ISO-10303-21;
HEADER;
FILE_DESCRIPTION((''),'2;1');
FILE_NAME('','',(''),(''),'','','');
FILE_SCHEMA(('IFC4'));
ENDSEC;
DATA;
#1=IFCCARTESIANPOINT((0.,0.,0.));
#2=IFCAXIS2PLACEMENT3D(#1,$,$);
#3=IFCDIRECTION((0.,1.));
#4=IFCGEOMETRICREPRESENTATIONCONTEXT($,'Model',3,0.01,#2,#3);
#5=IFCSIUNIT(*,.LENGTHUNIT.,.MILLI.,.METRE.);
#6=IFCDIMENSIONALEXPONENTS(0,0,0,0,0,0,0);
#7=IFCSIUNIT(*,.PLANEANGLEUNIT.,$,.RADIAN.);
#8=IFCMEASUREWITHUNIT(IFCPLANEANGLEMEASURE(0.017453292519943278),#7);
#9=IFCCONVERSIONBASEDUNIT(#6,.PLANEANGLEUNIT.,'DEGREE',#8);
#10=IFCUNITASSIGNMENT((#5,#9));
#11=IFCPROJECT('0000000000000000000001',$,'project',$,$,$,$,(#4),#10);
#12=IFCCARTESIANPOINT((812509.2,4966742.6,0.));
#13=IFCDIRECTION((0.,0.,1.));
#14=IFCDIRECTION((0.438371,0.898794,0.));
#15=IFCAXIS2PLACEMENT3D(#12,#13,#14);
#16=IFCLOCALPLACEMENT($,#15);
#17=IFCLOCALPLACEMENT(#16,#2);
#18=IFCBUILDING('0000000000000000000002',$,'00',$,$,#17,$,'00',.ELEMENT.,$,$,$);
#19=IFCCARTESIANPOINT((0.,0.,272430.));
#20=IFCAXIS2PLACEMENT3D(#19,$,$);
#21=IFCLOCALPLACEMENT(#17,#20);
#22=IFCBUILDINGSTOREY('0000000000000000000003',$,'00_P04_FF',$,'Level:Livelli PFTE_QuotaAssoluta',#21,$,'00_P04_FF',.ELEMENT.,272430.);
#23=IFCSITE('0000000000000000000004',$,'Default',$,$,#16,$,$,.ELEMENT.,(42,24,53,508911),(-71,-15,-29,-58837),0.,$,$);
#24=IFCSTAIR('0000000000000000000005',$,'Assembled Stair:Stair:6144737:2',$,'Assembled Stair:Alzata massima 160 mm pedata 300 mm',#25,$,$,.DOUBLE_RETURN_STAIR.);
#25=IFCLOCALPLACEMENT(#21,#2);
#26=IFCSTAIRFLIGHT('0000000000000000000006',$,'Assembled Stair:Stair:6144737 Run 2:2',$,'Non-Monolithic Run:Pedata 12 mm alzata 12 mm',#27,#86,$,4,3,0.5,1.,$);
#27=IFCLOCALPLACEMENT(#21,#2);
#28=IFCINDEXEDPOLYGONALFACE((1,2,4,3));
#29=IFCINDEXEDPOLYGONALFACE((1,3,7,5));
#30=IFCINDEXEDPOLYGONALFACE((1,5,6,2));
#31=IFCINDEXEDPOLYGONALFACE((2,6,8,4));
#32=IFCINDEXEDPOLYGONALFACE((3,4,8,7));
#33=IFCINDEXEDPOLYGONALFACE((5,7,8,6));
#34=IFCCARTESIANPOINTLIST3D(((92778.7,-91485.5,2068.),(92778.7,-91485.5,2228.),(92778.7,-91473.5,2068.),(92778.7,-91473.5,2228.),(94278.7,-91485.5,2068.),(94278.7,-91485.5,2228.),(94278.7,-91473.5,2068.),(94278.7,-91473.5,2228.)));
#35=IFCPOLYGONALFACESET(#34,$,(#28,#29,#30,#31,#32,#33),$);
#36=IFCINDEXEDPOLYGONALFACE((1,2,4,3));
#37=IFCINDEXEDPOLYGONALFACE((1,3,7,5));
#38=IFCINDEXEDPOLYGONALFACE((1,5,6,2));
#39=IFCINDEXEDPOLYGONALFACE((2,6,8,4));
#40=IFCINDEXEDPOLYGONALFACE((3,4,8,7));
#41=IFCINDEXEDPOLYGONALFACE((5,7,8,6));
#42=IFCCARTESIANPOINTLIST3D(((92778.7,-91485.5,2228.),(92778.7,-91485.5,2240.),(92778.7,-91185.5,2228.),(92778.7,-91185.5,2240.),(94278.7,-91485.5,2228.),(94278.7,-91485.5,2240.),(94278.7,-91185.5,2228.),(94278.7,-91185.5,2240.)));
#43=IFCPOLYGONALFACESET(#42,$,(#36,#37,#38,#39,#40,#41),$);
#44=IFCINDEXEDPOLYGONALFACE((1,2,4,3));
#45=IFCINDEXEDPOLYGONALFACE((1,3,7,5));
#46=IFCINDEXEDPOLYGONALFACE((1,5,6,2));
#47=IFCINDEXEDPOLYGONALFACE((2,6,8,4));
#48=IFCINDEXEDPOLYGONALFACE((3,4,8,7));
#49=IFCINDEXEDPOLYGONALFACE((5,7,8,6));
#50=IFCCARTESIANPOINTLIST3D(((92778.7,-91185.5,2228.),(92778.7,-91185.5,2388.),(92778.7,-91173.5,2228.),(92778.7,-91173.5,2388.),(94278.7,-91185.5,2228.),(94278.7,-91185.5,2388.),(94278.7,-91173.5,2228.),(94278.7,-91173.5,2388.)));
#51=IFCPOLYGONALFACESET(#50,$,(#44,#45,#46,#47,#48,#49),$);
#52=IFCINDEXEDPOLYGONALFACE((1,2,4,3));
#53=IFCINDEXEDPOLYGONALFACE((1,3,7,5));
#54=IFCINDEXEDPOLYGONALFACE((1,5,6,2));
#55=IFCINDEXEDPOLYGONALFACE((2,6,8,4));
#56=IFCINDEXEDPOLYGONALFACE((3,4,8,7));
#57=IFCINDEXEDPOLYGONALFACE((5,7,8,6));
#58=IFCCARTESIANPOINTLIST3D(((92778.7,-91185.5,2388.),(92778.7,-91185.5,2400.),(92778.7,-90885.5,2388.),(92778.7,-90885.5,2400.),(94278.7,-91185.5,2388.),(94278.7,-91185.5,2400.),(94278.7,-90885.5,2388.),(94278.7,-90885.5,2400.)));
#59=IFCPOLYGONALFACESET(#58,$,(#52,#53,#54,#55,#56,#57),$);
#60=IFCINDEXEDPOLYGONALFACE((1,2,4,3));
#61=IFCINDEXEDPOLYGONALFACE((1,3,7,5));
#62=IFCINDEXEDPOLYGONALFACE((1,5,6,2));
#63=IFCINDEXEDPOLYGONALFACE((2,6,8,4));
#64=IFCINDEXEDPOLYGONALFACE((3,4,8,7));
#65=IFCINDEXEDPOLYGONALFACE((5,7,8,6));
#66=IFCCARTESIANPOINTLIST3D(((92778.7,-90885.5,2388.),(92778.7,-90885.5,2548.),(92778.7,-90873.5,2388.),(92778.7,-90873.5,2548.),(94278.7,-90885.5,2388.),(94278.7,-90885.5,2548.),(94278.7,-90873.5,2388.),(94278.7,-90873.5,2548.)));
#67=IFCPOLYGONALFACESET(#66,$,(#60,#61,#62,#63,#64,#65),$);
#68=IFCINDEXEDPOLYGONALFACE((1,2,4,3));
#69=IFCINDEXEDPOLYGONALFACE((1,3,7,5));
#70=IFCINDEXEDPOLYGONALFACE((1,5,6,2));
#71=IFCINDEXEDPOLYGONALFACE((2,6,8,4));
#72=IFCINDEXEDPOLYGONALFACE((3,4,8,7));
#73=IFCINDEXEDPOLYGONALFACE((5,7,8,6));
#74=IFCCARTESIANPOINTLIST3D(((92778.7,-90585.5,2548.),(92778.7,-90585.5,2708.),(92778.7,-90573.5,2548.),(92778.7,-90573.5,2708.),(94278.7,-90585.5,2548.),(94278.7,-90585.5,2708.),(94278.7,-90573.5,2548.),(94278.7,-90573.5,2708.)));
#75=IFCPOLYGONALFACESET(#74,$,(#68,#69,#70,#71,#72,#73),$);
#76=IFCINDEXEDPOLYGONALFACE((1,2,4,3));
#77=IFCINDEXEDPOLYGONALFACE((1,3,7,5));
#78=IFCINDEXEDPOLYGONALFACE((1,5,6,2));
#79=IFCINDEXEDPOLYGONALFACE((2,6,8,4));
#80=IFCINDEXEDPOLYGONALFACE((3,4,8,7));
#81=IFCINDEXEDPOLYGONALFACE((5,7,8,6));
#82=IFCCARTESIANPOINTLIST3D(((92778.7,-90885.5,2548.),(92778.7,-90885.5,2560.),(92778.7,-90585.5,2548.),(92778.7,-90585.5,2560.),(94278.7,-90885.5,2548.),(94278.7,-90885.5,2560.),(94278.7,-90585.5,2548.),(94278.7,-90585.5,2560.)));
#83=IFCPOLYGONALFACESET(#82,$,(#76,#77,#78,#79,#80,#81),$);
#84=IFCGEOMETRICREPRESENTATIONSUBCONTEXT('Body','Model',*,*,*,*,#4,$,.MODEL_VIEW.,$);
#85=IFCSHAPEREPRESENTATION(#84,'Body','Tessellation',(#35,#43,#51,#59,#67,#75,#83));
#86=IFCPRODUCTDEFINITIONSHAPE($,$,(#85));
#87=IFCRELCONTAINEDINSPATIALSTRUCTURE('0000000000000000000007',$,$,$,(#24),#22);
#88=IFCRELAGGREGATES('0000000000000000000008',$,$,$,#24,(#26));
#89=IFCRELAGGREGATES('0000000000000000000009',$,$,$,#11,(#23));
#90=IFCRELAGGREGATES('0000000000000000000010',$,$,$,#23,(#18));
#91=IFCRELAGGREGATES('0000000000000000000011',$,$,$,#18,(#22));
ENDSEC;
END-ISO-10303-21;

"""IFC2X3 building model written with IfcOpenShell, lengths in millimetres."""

from ifc_helpers import new_model, entity, si_unit, converted_unit, direction, frame, frame_2d, origin, origin_2d_with_axis, place, context, subcontext, project, spatial, rectangle, extrude, element, aggregate, save


model = new_model("IFC2X3")

# Units and contexts
model_context = context("Model", 3, precision=0.01, world=origin(), true_north=direction((0.0, 1.0)))
body_context = subcontext(model_context, "Body", "Model", "MODEL_VIEW")
ifc_project = project(units=[si_unit("LENGTHUNIT", "METRE", prefix="MILLI"), converted_unit("PLANEANGLEUNIT", "DEGREE", entity("IfcPlaneAngleMeasure", 0.017453292519943278), si_unit("PLANEANGLEUNIT", "RADIAN"), dimensions=[0, 0, 0, 0, 0, 0, 0])], contexts=[model_context])

# Site, building, storey
site_placement = place(None, frame((812509.2, 4966742.6, 0.0), z_axis=(0.0, 0.0, 1.0), x_axis=(0.438371, 0.898794, 0.0)))
site = spatial("IfcSite", under=ifc_project, at=site_placement, Name="Default", CompositionType="ELEMENT", RefLatitude=(42, 24, 53, 508911), RefLongitude=(-71, -15, -29, -58837), RefElevation=0.0)
building_placement = place(site_placement, origin())
building = spatial("IfcBuilding", under=site, at=building_placement, Name="00", LongName="00", CompositionType="ELEMENT")
storey_placement = place(building_placement, frame((0.0, 0.0, 272430.0)))
storey = spatial("IfcBuildingStorey", under=building, at=storey_placement, Name="00_P04_FF", ObjectType="Level:Livelli PFTE_QuotaAssoluta", LongName="00_P04_FF", CompositionType="ELEMENT", Elevation=272430.0)

# Stair
stair_1_placement = place(storey_placement, origin())
stair_1 = element("IfcStair", 1, at=stair_1_placement, inside=storey, Name="Assembled Stair:Stair:6144737:2", ObjectType="Assembled Stair:Alzata massima 160 mm pedata 300 mm", ShapeType="DOUBLE_RETURN_STAIR")

# Stair flight
stair_flight_1_placement = place(stair_1_placement, origin())
stair_flight_1 = element("IfcStairFlight", 2, at=stair_flight_1_placement, Name="Assembled Stair:Stair:6144737 Run 2:2", ObjectType="Non-Monolithic Run:Pedata 12 mm alzata 12 mm", NumberOfRiser=4, NumberOfTreads=3, RiserHeight=0.5, TreadLength=1.0, context=body_context, shape_type="SweptSolid", body=[
    extrude(rectangle(XDim=1500.0, YDim=12.0, at=origin_2d_with_axis()), frame((93528.7, -91479.5, 2068.0), z_axis=(0.0, 0.0, 1.0), x_axis=(-1.0, 0.0, 0.0)), (0.0, 0.0, 1.0), 160.0),
    extrude(rectangle(XDim=300.0, YDim=1500.0, at=frame_2d((0.0, 0.0), x_axis=(1.0, 0.0))), frame((93528.7, -91335.5, 2228.0), z_axis=(0.0, 0.0, 1.0), x_axis=(0.0, -1.0, 0.0)), (0.0, 0.0, 1.0), 12.0),
    extrude(rectangle(XDim=1500.0, YDim=12.0, at=frame_2d((0.0, 0.0), x_axis=(1.0, 0.0))), frame((93528.7, -91179.5, 2228.0), z_axis=(0.0, 0.0, 1.0), x_axis=(-1.0, 0.0, 0.0)), (0.0, 0.0, 1.0), 160.0),
    extrude(rectangle(XDim=300.0, YDim=1500.0, at=origin_2d_with_axis()), frame((93528.7, -91035.5, 2388.0), z_axis=(0.0, 0.0, 1.0), x_axis=(0.0, -1.0, 0.0)), (0.0, 0.0, 1.0), 12.0),
    extrude(rectangle(XDim=1500.0, YDim=12.0, at=frame_2d((0.0, 0.0), x_axis=(1.0, 0.0))), frame((93528.7, -90879.5, 2388.0), z_axis=(0.0, 0.0, 1.0), x_axis=(-1.0, 0.0, 0.0)), (0.0, 0.0, 1.0), 160.0),
    extrude(rectangle(XDim=1500.0, YDim=12.0, at=origin_2d_with_axis()), frame((93528.7, -90579.5, 2548.0), z_axis=(0.0, 0.0, 1.0), x_axis=(-1.0, 0.0, 0.0)), (0.0, 0.0, 1.0), 160.0),
    extrude(rectangle(XDim=300.0, YDim=1500.0, at=origin_2d_with_axis()), frame((93528.7, -90735.5, 2548.0), z_axis=(0.0, 0.0, 1.0), x_axis=(0.0, -1.0, 0.0)), (0.0, 0.0, 1.0), 12.0),
])
aggregate(stair_1, [stair_flight_1])

save(model, "model.ifc")
